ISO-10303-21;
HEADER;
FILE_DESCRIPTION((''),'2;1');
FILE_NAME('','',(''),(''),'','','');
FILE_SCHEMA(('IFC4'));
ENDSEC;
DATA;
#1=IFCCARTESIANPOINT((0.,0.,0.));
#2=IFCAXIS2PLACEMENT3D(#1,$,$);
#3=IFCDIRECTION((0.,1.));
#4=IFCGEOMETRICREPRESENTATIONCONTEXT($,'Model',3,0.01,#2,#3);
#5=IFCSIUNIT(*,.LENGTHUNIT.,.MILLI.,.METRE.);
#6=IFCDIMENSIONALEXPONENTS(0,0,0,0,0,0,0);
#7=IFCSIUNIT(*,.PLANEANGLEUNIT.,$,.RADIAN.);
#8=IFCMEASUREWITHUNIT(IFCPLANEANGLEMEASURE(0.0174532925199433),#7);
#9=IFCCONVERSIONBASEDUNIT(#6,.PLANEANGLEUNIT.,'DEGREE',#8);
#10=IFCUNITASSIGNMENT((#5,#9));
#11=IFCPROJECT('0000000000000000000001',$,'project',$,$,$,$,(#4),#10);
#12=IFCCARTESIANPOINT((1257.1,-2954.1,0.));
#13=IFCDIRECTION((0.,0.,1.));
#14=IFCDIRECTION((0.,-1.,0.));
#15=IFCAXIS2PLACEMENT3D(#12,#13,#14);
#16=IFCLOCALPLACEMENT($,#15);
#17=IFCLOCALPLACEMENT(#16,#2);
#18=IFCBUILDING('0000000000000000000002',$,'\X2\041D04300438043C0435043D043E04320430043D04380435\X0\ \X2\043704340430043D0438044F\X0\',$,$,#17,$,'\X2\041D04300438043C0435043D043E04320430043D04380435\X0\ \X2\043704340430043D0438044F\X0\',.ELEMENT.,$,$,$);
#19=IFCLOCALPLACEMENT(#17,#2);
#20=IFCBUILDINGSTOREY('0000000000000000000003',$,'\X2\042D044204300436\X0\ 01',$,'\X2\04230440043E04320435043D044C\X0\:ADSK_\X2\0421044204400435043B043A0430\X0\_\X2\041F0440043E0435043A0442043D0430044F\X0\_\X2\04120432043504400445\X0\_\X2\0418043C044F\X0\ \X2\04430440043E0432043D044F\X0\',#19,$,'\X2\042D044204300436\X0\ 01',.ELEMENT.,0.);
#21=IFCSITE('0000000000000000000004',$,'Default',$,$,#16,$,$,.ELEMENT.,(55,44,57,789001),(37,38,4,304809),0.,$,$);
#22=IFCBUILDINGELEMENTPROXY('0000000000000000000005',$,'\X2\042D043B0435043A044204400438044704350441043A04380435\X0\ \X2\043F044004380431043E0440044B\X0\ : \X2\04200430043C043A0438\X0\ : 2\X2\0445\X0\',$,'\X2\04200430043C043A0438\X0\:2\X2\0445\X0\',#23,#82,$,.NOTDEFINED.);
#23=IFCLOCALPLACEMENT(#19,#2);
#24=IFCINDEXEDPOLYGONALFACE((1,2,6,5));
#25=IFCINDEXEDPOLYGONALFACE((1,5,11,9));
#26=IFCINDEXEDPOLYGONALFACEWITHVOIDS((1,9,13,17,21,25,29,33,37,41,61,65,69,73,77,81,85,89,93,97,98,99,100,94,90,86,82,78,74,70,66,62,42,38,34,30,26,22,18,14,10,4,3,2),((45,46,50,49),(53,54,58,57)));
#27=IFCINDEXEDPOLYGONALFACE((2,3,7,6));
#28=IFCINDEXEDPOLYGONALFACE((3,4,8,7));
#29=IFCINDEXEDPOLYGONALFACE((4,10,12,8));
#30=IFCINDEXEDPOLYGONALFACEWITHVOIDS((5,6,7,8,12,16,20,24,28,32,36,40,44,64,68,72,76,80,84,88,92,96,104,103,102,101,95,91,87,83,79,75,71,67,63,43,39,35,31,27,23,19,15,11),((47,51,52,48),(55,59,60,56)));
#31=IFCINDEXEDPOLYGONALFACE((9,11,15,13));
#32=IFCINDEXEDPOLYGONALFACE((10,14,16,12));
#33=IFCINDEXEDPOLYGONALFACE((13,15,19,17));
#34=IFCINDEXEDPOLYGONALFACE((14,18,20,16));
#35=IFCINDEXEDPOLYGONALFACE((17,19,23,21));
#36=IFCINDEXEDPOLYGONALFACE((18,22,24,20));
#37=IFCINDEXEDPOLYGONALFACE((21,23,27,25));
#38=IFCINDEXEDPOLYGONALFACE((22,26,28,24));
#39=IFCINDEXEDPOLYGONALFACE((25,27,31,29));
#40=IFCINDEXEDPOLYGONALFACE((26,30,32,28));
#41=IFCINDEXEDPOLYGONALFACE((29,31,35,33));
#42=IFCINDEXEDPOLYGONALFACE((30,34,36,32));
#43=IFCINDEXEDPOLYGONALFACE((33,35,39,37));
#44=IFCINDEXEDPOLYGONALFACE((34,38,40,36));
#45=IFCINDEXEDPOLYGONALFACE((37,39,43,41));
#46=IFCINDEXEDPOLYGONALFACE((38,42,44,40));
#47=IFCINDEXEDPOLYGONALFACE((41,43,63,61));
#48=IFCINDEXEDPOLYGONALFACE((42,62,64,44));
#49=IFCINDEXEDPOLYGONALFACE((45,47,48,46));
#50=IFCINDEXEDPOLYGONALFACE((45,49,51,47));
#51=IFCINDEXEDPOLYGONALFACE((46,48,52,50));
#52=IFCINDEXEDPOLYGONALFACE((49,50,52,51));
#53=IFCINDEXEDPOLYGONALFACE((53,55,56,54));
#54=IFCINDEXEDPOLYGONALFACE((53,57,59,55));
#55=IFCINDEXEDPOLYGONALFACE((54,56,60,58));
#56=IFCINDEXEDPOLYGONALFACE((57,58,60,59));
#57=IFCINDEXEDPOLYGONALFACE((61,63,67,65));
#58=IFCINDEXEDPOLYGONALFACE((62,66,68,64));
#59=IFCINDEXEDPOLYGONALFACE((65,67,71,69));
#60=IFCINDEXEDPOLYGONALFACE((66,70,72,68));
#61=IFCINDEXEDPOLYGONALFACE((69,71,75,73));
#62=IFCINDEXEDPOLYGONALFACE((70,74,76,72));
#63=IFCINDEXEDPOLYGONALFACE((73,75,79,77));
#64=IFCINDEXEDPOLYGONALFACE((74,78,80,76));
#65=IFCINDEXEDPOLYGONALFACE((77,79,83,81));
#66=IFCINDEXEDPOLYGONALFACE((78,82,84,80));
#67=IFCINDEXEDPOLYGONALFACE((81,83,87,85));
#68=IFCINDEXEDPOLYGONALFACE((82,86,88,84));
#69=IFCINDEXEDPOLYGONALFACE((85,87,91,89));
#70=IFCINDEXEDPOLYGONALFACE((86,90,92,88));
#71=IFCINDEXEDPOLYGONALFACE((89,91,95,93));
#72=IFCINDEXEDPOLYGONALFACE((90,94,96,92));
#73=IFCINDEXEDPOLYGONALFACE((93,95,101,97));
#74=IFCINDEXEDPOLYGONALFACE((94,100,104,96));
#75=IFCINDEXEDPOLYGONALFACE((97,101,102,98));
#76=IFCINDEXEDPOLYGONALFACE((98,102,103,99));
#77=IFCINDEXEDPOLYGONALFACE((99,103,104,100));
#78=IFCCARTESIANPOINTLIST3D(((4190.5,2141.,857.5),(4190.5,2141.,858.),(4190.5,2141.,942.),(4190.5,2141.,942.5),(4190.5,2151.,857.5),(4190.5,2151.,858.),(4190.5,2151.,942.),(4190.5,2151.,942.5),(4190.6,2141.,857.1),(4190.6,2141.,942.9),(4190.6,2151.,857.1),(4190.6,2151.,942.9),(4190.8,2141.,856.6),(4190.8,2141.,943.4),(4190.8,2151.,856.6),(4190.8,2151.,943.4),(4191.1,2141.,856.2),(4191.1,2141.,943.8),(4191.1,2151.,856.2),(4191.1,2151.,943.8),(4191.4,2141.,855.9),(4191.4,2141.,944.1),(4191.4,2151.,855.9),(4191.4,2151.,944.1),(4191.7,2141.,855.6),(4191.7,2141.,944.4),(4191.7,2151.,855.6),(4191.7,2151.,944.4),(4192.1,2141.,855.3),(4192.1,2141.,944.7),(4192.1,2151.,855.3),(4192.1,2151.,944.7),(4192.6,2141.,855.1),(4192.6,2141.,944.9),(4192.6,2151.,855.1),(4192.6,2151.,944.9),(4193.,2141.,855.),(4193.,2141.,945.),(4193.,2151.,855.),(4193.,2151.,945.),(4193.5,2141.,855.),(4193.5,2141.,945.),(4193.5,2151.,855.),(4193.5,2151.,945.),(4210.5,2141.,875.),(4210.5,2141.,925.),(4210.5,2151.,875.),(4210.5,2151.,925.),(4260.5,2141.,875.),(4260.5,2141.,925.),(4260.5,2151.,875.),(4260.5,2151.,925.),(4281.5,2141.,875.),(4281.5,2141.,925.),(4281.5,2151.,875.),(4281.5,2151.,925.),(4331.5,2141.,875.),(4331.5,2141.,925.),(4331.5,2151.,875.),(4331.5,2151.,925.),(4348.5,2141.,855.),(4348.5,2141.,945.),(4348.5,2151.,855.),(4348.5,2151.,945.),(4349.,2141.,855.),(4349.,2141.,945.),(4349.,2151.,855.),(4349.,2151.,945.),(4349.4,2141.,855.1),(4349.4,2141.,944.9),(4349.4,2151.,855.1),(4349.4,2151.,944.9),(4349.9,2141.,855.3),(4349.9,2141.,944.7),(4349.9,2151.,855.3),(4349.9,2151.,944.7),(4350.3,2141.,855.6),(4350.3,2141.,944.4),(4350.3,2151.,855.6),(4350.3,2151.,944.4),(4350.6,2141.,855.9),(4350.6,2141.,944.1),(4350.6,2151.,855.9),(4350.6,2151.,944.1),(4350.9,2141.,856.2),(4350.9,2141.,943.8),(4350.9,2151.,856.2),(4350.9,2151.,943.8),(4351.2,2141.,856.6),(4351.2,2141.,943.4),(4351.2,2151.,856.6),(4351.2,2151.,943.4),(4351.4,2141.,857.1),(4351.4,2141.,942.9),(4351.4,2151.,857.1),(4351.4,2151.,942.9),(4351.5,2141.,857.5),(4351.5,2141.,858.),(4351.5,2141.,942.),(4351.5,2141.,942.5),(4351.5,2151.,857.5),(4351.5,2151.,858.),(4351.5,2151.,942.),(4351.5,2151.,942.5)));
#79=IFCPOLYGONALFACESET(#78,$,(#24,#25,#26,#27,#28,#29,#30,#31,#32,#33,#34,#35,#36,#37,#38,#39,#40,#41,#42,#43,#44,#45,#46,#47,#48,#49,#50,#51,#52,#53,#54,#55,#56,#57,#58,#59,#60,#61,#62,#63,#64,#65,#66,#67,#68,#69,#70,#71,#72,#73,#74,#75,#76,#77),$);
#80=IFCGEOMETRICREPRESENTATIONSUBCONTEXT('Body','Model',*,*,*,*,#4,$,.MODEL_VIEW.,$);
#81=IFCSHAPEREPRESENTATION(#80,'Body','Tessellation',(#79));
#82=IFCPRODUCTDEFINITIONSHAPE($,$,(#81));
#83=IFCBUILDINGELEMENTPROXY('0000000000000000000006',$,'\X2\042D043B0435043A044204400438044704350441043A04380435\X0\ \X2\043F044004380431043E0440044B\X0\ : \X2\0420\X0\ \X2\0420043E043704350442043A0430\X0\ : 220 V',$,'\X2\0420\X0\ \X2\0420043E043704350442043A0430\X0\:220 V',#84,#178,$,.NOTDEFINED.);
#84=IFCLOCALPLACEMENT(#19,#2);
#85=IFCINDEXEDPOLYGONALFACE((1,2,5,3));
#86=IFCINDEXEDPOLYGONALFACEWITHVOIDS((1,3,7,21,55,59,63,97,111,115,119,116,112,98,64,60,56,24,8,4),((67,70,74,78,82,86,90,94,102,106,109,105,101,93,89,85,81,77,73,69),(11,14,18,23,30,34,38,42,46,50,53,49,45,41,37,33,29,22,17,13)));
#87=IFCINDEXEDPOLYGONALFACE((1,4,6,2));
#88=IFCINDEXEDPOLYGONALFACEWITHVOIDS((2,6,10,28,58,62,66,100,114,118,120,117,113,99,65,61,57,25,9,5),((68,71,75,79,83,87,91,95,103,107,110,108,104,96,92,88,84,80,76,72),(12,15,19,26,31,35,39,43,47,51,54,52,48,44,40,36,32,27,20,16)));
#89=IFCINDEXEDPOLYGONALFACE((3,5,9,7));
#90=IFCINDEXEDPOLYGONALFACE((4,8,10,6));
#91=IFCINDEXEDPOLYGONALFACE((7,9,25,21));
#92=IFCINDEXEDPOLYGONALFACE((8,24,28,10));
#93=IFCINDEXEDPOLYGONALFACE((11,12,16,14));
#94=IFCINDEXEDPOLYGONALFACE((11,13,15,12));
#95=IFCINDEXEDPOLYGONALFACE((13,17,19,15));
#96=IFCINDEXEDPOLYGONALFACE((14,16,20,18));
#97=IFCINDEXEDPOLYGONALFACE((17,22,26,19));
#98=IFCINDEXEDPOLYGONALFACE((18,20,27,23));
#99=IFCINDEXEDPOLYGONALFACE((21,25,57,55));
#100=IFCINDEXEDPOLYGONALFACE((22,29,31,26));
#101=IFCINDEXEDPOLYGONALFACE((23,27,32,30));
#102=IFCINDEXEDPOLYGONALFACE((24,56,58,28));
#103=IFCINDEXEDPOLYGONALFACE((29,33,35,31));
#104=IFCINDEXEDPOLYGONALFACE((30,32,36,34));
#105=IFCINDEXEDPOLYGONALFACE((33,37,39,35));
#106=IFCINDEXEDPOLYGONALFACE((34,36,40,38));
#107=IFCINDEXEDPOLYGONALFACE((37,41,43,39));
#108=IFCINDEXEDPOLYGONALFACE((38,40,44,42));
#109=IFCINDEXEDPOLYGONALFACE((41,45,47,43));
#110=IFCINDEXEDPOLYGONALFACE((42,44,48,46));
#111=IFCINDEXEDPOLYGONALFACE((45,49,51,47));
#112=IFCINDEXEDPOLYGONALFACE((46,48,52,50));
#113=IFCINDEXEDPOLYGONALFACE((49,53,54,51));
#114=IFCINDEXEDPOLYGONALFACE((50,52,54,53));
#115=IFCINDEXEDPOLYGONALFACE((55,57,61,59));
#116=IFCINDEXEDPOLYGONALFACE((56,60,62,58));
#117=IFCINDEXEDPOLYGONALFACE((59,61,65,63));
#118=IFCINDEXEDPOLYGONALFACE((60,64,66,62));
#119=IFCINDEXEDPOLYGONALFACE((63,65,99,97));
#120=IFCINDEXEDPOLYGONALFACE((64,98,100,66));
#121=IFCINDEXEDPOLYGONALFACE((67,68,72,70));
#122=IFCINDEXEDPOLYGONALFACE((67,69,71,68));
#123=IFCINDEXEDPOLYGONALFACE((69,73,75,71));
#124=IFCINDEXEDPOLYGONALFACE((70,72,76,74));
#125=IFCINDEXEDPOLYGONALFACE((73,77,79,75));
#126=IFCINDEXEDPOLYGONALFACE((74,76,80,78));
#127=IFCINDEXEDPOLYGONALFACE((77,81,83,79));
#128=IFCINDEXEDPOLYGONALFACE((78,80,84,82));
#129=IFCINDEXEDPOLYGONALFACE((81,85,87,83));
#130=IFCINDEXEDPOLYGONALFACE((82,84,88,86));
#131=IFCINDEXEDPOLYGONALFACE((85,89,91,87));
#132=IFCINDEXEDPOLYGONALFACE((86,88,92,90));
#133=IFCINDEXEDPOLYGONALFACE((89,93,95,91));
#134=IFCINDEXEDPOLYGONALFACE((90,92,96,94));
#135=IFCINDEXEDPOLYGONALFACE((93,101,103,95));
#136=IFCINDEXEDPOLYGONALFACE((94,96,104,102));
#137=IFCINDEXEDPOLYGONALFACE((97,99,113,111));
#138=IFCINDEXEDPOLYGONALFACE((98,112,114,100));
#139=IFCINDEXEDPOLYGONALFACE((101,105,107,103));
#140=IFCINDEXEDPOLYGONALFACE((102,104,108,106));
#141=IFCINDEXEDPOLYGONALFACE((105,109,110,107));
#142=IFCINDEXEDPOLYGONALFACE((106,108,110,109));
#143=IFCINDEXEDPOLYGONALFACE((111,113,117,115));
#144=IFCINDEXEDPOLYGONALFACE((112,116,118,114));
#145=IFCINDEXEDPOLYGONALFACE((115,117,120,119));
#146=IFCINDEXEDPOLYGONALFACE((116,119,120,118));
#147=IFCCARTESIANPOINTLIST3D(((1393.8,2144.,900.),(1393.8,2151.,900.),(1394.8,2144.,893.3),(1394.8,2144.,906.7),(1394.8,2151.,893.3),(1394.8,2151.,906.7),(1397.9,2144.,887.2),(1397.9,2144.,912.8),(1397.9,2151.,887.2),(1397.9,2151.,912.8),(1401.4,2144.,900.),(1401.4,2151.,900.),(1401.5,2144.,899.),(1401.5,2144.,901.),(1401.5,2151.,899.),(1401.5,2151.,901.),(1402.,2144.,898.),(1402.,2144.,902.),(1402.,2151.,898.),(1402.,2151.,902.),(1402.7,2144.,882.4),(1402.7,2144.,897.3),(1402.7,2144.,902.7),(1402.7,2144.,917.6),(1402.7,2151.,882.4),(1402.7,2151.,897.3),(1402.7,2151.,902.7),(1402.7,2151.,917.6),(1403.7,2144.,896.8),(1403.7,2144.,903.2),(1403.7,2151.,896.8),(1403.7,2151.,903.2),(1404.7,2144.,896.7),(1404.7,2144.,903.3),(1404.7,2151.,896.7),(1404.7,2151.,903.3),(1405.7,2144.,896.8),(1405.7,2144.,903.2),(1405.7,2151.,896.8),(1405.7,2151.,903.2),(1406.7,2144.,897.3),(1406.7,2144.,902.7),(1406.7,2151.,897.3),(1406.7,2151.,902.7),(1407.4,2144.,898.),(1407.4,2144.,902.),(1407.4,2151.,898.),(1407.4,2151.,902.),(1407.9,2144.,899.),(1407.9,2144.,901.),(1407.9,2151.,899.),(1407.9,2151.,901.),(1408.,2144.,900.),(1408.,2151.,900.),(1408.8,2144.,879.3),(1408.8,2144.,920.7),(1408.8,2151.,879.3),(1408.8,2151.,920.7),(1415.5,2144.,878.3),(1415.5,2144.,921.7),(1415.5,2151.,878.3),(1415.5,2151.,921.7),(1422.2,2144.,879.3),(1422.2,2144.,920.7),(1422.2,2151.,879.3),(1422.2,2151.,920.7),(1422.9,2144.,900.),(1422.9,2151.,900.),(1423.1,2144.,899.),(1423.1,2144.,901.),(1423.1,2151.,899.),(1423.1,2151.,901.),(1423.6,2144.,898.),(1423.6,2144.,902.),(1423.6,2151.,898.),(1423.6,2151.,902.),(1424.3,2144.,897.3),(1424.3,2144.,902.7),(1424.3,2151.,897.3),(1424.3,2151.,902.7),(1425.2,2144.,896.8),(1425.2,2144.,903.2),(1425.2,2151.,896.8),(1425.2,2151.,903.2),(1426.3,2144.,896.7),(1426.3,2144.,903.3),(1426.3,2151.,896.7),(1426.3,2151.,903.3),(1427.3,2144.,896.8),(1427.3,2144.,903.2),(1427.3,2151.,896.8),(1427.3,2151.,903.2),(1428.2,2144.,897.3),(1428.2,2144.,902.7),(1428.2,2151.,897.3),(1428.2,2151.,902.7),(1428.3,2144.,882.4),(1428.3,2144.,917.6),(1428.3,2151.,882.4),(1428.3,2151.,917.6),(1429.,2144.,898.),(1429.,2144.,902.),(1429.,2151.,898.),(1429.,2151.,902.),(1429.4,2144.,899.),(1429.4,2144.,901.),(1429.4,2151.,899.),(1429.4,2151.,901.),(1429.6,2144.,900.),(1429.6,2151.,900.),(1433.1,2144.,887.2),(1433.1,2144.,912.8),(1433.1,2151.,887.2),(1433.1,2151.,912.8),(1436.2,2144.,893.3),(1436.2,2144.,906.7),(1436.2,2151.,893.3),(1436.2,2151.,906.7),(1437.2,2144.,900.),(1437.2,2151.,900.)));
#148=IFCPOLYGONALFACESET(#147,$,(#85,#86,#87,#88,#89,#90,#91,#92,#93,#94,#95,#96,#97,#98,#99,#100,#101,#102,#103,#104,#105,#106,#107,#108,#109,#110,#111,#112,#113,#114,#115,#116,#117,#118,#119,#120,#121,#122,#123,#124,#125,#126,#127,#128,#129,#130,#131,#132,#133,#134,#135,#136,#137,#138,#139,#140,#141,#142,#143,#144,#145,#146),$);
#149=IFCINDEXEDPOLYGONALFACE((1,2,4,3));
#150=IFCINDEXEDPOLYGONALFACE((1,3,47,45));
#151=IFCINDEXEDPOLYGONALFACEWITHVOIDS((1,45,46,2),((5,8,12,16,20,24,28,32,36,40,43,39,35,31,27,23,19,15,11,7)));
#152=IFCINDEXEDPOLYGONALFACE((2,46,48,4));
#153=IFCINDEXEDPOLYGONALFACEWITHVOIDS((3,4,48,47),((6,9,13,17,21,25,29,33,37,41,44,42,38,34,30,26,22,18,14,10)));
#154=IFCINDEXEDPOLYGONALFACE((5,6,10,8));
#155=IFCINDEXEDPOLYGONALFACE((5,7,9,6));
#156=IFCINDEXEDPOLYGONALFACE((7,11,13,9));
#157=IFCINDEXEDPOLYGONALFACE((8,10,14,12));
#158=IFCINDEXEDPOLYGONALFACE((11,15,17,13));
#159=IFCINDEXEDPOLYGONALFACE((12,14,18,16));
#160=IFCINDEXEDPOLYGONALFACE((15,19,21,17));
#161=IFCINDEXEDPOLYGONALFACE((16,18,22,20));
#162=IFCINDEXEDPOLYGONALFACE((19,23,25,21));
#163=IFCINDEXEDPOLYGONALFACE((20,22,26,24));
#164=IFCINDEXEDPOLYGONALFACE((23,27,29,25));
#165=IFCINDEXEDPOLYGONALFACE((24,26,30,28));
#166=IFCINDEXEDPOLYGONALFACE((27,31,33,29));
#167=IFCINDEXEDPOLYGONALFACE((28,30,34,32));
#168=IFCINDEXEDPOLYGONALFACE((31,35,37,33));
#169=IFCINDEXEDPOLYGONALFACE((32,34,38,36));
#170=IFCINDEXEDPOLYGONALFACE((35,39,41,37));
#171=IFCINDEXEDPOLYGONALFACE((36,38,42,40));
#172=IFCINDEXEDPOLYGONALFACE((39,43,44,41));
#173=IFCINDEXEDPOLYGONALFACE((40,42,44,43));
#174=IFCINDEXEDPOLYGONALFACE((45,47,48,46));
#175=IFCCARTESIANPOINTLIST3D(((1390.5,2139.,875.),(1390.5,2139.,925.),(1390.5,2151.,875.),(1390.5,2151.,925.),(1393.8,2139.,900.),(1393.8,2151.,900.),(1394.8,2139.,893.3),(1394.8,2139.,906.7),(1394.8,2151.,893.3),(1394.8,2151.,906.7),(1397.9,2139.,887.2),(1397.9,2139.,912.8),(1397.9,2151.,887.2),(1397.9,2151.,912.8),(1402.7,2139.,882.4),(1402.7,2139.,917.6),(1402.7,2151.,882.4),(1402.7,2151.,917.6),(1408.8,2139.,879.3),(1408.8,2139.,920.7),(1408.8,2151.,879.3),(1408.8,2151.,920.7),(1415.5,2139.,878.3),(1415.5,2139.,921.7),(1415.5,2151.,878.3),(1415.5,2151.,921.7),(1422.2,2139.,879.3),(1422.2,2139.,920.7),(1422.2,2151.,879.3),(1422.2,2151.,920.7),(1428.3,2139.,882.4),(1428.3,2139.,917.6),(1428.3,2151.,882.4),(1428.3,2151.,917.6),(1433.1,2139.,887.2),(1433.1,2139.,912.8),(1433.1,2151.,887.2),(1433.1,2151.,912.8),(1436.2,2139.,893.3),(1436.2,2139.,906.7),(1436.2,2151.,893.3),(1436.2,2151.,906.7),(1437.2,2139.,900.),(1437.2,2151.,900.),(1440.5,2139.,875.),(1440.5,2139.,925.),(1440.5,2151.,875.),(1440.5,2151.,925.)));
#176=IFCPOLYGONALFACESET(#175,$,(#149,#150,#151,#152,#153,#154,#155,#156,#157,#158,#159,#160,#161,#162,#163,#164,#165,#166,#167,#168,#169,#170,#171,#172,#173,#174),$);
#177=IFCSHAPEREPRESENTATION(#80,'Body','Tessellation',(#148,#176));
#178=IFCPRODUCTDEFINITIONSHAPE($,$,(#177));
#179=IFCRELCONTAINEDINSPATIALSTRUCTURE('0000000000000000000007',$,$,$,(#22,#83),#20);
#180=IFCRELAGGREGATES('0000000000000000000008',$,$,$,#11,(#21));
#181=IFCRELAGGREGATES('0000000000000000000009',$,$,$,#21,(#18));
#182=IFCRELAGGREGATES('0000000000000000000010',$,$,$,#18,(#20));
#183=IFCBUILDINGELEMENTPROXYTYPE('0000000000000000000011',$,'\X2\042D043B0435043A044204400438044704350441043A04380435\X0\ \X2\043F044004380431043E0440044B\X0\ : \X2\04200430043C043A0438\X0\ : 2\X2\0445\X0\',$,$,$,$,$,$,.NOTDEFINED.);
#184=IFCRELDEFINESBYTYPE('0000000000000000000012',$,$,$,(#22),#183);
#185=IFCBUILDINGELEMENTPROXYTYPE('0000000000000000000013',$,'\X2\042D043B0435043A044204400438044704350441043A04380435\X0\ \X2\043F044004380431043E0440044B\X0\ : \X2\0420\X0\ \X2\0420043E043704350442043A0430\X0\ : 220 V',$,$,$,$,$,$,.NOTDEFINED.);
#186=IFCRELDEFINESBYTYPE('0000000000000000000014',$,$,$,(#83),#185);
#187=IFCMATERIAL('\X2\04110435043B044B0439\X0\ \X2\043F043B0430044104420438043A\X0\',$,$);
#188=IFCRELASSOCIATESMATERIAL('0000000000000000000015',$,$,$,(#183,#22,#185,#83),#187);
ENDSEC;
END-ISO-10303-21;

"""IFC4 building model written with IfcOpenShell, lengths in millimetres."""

from ifc_helpers import new_model, entity, si_unit, converted_unit, direction, frame, origin, place, context, subcontext, project, spatial, indexed_curve, outline, extrude, source, transform, mapped, material, type_object, type_shapes, element, save


model = new_model("IFC4")

# Units and contexts
model_context = context("Model", 3, precision=0.01, world=origin(), true_north=direction((0.0, 1.0)))
body_context = subcontext(model_context, "Body", "Model", "MODEL_VIEW")
ifc_project = project(units=[si_unit("LENGTHUNIT", "METRE", prefix="MILLI"), converted_unit("PLANEANGLEUNIT", "DEGREE", entity("IfcPlaneAngleMeasure", 0.0174532925199433), si_unit("PLANEANGLEUNIT", "RADIAN"), dimensions=[0, 0, 0, 0, 0, 0, 0])], contexts=[model_context])

# Site, building, storey
site_placement = place(None, frame((1257.1, -2954.1, 0.0), z_axis=(0.0, 0.0, 1.0), x_axis=(0.0, -1.0, 0.0)))
site = spatial("IfcSite", under=ifc_project, at=site_placement, Name="Default", CompositionType="ELEMENT", RefLatitude=(55, 44, 57, 789001), RefLongitude=(37, 38, 4, 304809), RefElevation=0.0)
building_placement = place(site_placement, origin())
building = spatial("IfcBuilding", under=site, at=building_placement, Name="Наименование здания", LongName="Наименование здания", CompositionType="ELEMENT")
storey_placement = place(building_placement, origin())
storey = spatial("IfcBuildingStorey", under=building, at=storey_placement, Name="Этаж 01", ObjectType="Уровень:ADSK_Стрелка_Проектная_Вверх_Имя уровня", LongName="Этаж 01", CompositionType="ELEMENT", Elevation=0.0)

# Building element proxies
ifc_material_1 = material(Name="Белый пластик")
building_element_proxy_type_1 = type_object("IfcBuildingElementProxyType", Name="Электрические приборы : Рамки : 2х", PredefinedType="NOTDEFINED", material=ifc_material_1)
shared_shape_1 = source(origin(), body_context, "Body", "SweptSolid", [
    extrude(outline(indexed_curve([(-77.5, 45.0), (-78.0, 45.0), (-78.4, 44.9), (-78.9, 44.7), (-79.3, 44.4), (-79.6, 44.1), (-79.9, 43.8), (-80.2, 43.4), (-80.4, 42.9), (-80.5, 42.5), (-80.5, 42.0), (-80.5, -42.0), (-80.5, -42.5), (-80.4, -42.9), (-80.2, -43.4), (-79.9, -43.8), (-79.6, -44.1), (-79.3, -44.4), (-78.9, -44.7), (-78.4, -44.9), (-78.0, -45.0), (-77.5, -45.0), (77.5, -45.0), (78.0, -45.0), (78.4, -44.9), (78.9, -44.7), (79.3, -44.4), (79.6, -44.1), (79.9, -43.8), (80.2, -43.4), (80.4, -42.9), (80.5, -42.5), (80.5, -42.0), (80.5, 42.0), (80.5, 42.5), (80.4, 42.9), (80.2, 43.4), (79.9, 43.8), (79.6, 44.1), (79.3, 44.4), (78.9, 44.7), (78.4, 44.9), (78.0, 45.0), (77.5, 45.0), (-77.5, 45.0)], self_intersect=False), holes=[indexed_curve([(-60.5, 25.0), (-10.5, 25.0), (-10.5, -25.0), (-60.5, -25.0), (-60.5, 25.0)], self_intersect=False), indexed_curve([(10.5, 25.0), (60.5, 25.0), (60.5, -25.0), (10.5, -25.0), (10.5, 25.0)], self_intersect=False)]), frame((35.5, 0.0, 0.0)), (0.0, 0.0, 1.0), 10.0),
])
type_shapes(building_element_proxy_type_1, [shared_shape_1])
for number, where, z_axis, x_axis, name in (
    (1, (4235.5, 2151.0, 900.0), (0.0, -1.0, 0.0), (1.0, 0.0, 0.0), "Электрические приборы : Рамки : 2х"),
):
    element("IfcBuildingElementProxy", number, at=place(storey_placement, frame(where, z_axis=z_axis, x_axis=x_axis)), inside=storey, type_object=building_element_proxy_type_1, material=ifc_material_1, Name=name, ObjectType="Рамки:2х", PredefinedType="NOTDEFINED", context=body_context, shape_type="MappedRepresentation", body=[
        mapped(shared_shape_1, transform((0.0, 0.0, 0.0), scale=1.0)),
    ])
building_element_proxy_type_2 = type_object("IfcBuildingElementProxyType", Name="Электрические приборы : Р Розетка : 220 V", PredefinedType="NOTDEFINED", material=ifc_material_1)
shared_shape_2 = source(origin(), body_context, "Body", "SweptSolid", [
    extrude(outline(indexed_curve([(21.7, 0.0), (20.7, 6.7), (17.6, 12.8), (12.8, 17.6), (6.7, 20.7), (0.0, 21.7), (-6.7, 20.7), (-12.8, 17.6), (-17.6, 12.8), (-20.7, 6.7), (-21.7, 0.0), (-20.7, -6.7), (-17.6, -12.8), (-12.8, -17.6), (-6.7, -20.7), (0.0, -21.7), (6.7, -20.7), (12.8, -17.6), (17.6, -12.8), (20.7, -6.7), (21.7, 0.0)], self_intersect=False), holes=[indexed_curve([(-7.5, 0.0), (-7.6, -1.0), (-8.1, -2.0), (-8.8, -2.7), (-9.8, -3.2), (-10.8, -3.3), (-11.8, -3.2), (-12.8, -2.7), (-13.5, -2.0), (-14.0, -1.0), (-14.1, 0.0), (-14.0, 1.0), (-13.5, 2.0), (-12.8, 2.7), (-11.8, 3.2), (-10.8, 3.3), (-9.8, 3.2), (-8.8, 2.7), (-8.1, 2.0), (-7.6, 1.0), (-7.5, 0.0)], self_intersect=False), indexed_curve([(14.1, 0.0), (13.9, -1.0), (13.5, -2.0), (12.7, -2.7), (11.8, -3.2), (10.8, -3.3), (9.7, -3.2), (8.8, -2.7), (8.1, -2.0), (7.6, -1.0), (7.4, 0.0), (7.6, 1.0), (8.1, 2.0), (8.8, 2.7), (9.7, 3.2), (10.8, 3.3), (11.8, 3.2), (12.7, 2.7), (13.5, 2.0), (13.9, 1.0), (14.1, 0.0)], self_intersect=False)]), frame((374.3, -712.5, 0.0)), (0.0, 0.0, 1.0), 7.0),
    extrude(outline(indexed_curve([(-25.0, -25.0), (25.0, -25.0), (25.0, 25.0), (-25.0, 25.0), (-25.0, -25.0)], self_intersect=False), holes=[indexed_curve([(-21.7, 0.0), (-20.7, 6.7), (-17.6, 12.8), (-12.8, 17.6), (-6.7, 20.7), (0.0, 21.7), (6.7, 20.7), (12.8, 17.6), (17.6, 12.8), (20.7, 6.7), (21.7, 0.0), (20.7, -6.7), (17.6, -12.8), (12.8, -17.6), (6.7, -20.7), (0.0, -21.7), (-6.7, -20.7), (-12.8, -17.6), (-17.6, -12.8), (-20.7, -6.7), (-21.7, 0.0)], self_intersect=False)]), frame((374.3, -712.5, 0.0), z_axis=(0.0, 0.0, 1.0), x_axis=(-1.0, 0.0, 0.0)), (0.0, 0.0, 1.0), 12.0),
])
type_shapes(building_element_proxy_type_2, [shared_shape_2])
for number, where, z_axis, x_axis, name in (
    (2, (1041.2, 2151.0, 1612.5), (0.0, -1.0, 0.0), (1.0, 0.0, 0.0), "Электрические приборы : Р Розетка : 220 V"),
):
    element("IfcBuildingElementProxy", number, at=place(storey_placement, frame(where, z_axis=z_axis, x_axis=x_axis)), inside=storey, type_object=building_element_proxy_type_2, material=ifc_material_1, Name=name, ObjectType="Р Розетка:220 V", PredefinedType="NOTDEFINED", context=body_context, shape_type="MappedRepresentation", body=[
        mapped(shared_shape_2, transform((0.0, 0.0, 0.0), scale=1.0)),
    ])

save(model, "model.ifc")
